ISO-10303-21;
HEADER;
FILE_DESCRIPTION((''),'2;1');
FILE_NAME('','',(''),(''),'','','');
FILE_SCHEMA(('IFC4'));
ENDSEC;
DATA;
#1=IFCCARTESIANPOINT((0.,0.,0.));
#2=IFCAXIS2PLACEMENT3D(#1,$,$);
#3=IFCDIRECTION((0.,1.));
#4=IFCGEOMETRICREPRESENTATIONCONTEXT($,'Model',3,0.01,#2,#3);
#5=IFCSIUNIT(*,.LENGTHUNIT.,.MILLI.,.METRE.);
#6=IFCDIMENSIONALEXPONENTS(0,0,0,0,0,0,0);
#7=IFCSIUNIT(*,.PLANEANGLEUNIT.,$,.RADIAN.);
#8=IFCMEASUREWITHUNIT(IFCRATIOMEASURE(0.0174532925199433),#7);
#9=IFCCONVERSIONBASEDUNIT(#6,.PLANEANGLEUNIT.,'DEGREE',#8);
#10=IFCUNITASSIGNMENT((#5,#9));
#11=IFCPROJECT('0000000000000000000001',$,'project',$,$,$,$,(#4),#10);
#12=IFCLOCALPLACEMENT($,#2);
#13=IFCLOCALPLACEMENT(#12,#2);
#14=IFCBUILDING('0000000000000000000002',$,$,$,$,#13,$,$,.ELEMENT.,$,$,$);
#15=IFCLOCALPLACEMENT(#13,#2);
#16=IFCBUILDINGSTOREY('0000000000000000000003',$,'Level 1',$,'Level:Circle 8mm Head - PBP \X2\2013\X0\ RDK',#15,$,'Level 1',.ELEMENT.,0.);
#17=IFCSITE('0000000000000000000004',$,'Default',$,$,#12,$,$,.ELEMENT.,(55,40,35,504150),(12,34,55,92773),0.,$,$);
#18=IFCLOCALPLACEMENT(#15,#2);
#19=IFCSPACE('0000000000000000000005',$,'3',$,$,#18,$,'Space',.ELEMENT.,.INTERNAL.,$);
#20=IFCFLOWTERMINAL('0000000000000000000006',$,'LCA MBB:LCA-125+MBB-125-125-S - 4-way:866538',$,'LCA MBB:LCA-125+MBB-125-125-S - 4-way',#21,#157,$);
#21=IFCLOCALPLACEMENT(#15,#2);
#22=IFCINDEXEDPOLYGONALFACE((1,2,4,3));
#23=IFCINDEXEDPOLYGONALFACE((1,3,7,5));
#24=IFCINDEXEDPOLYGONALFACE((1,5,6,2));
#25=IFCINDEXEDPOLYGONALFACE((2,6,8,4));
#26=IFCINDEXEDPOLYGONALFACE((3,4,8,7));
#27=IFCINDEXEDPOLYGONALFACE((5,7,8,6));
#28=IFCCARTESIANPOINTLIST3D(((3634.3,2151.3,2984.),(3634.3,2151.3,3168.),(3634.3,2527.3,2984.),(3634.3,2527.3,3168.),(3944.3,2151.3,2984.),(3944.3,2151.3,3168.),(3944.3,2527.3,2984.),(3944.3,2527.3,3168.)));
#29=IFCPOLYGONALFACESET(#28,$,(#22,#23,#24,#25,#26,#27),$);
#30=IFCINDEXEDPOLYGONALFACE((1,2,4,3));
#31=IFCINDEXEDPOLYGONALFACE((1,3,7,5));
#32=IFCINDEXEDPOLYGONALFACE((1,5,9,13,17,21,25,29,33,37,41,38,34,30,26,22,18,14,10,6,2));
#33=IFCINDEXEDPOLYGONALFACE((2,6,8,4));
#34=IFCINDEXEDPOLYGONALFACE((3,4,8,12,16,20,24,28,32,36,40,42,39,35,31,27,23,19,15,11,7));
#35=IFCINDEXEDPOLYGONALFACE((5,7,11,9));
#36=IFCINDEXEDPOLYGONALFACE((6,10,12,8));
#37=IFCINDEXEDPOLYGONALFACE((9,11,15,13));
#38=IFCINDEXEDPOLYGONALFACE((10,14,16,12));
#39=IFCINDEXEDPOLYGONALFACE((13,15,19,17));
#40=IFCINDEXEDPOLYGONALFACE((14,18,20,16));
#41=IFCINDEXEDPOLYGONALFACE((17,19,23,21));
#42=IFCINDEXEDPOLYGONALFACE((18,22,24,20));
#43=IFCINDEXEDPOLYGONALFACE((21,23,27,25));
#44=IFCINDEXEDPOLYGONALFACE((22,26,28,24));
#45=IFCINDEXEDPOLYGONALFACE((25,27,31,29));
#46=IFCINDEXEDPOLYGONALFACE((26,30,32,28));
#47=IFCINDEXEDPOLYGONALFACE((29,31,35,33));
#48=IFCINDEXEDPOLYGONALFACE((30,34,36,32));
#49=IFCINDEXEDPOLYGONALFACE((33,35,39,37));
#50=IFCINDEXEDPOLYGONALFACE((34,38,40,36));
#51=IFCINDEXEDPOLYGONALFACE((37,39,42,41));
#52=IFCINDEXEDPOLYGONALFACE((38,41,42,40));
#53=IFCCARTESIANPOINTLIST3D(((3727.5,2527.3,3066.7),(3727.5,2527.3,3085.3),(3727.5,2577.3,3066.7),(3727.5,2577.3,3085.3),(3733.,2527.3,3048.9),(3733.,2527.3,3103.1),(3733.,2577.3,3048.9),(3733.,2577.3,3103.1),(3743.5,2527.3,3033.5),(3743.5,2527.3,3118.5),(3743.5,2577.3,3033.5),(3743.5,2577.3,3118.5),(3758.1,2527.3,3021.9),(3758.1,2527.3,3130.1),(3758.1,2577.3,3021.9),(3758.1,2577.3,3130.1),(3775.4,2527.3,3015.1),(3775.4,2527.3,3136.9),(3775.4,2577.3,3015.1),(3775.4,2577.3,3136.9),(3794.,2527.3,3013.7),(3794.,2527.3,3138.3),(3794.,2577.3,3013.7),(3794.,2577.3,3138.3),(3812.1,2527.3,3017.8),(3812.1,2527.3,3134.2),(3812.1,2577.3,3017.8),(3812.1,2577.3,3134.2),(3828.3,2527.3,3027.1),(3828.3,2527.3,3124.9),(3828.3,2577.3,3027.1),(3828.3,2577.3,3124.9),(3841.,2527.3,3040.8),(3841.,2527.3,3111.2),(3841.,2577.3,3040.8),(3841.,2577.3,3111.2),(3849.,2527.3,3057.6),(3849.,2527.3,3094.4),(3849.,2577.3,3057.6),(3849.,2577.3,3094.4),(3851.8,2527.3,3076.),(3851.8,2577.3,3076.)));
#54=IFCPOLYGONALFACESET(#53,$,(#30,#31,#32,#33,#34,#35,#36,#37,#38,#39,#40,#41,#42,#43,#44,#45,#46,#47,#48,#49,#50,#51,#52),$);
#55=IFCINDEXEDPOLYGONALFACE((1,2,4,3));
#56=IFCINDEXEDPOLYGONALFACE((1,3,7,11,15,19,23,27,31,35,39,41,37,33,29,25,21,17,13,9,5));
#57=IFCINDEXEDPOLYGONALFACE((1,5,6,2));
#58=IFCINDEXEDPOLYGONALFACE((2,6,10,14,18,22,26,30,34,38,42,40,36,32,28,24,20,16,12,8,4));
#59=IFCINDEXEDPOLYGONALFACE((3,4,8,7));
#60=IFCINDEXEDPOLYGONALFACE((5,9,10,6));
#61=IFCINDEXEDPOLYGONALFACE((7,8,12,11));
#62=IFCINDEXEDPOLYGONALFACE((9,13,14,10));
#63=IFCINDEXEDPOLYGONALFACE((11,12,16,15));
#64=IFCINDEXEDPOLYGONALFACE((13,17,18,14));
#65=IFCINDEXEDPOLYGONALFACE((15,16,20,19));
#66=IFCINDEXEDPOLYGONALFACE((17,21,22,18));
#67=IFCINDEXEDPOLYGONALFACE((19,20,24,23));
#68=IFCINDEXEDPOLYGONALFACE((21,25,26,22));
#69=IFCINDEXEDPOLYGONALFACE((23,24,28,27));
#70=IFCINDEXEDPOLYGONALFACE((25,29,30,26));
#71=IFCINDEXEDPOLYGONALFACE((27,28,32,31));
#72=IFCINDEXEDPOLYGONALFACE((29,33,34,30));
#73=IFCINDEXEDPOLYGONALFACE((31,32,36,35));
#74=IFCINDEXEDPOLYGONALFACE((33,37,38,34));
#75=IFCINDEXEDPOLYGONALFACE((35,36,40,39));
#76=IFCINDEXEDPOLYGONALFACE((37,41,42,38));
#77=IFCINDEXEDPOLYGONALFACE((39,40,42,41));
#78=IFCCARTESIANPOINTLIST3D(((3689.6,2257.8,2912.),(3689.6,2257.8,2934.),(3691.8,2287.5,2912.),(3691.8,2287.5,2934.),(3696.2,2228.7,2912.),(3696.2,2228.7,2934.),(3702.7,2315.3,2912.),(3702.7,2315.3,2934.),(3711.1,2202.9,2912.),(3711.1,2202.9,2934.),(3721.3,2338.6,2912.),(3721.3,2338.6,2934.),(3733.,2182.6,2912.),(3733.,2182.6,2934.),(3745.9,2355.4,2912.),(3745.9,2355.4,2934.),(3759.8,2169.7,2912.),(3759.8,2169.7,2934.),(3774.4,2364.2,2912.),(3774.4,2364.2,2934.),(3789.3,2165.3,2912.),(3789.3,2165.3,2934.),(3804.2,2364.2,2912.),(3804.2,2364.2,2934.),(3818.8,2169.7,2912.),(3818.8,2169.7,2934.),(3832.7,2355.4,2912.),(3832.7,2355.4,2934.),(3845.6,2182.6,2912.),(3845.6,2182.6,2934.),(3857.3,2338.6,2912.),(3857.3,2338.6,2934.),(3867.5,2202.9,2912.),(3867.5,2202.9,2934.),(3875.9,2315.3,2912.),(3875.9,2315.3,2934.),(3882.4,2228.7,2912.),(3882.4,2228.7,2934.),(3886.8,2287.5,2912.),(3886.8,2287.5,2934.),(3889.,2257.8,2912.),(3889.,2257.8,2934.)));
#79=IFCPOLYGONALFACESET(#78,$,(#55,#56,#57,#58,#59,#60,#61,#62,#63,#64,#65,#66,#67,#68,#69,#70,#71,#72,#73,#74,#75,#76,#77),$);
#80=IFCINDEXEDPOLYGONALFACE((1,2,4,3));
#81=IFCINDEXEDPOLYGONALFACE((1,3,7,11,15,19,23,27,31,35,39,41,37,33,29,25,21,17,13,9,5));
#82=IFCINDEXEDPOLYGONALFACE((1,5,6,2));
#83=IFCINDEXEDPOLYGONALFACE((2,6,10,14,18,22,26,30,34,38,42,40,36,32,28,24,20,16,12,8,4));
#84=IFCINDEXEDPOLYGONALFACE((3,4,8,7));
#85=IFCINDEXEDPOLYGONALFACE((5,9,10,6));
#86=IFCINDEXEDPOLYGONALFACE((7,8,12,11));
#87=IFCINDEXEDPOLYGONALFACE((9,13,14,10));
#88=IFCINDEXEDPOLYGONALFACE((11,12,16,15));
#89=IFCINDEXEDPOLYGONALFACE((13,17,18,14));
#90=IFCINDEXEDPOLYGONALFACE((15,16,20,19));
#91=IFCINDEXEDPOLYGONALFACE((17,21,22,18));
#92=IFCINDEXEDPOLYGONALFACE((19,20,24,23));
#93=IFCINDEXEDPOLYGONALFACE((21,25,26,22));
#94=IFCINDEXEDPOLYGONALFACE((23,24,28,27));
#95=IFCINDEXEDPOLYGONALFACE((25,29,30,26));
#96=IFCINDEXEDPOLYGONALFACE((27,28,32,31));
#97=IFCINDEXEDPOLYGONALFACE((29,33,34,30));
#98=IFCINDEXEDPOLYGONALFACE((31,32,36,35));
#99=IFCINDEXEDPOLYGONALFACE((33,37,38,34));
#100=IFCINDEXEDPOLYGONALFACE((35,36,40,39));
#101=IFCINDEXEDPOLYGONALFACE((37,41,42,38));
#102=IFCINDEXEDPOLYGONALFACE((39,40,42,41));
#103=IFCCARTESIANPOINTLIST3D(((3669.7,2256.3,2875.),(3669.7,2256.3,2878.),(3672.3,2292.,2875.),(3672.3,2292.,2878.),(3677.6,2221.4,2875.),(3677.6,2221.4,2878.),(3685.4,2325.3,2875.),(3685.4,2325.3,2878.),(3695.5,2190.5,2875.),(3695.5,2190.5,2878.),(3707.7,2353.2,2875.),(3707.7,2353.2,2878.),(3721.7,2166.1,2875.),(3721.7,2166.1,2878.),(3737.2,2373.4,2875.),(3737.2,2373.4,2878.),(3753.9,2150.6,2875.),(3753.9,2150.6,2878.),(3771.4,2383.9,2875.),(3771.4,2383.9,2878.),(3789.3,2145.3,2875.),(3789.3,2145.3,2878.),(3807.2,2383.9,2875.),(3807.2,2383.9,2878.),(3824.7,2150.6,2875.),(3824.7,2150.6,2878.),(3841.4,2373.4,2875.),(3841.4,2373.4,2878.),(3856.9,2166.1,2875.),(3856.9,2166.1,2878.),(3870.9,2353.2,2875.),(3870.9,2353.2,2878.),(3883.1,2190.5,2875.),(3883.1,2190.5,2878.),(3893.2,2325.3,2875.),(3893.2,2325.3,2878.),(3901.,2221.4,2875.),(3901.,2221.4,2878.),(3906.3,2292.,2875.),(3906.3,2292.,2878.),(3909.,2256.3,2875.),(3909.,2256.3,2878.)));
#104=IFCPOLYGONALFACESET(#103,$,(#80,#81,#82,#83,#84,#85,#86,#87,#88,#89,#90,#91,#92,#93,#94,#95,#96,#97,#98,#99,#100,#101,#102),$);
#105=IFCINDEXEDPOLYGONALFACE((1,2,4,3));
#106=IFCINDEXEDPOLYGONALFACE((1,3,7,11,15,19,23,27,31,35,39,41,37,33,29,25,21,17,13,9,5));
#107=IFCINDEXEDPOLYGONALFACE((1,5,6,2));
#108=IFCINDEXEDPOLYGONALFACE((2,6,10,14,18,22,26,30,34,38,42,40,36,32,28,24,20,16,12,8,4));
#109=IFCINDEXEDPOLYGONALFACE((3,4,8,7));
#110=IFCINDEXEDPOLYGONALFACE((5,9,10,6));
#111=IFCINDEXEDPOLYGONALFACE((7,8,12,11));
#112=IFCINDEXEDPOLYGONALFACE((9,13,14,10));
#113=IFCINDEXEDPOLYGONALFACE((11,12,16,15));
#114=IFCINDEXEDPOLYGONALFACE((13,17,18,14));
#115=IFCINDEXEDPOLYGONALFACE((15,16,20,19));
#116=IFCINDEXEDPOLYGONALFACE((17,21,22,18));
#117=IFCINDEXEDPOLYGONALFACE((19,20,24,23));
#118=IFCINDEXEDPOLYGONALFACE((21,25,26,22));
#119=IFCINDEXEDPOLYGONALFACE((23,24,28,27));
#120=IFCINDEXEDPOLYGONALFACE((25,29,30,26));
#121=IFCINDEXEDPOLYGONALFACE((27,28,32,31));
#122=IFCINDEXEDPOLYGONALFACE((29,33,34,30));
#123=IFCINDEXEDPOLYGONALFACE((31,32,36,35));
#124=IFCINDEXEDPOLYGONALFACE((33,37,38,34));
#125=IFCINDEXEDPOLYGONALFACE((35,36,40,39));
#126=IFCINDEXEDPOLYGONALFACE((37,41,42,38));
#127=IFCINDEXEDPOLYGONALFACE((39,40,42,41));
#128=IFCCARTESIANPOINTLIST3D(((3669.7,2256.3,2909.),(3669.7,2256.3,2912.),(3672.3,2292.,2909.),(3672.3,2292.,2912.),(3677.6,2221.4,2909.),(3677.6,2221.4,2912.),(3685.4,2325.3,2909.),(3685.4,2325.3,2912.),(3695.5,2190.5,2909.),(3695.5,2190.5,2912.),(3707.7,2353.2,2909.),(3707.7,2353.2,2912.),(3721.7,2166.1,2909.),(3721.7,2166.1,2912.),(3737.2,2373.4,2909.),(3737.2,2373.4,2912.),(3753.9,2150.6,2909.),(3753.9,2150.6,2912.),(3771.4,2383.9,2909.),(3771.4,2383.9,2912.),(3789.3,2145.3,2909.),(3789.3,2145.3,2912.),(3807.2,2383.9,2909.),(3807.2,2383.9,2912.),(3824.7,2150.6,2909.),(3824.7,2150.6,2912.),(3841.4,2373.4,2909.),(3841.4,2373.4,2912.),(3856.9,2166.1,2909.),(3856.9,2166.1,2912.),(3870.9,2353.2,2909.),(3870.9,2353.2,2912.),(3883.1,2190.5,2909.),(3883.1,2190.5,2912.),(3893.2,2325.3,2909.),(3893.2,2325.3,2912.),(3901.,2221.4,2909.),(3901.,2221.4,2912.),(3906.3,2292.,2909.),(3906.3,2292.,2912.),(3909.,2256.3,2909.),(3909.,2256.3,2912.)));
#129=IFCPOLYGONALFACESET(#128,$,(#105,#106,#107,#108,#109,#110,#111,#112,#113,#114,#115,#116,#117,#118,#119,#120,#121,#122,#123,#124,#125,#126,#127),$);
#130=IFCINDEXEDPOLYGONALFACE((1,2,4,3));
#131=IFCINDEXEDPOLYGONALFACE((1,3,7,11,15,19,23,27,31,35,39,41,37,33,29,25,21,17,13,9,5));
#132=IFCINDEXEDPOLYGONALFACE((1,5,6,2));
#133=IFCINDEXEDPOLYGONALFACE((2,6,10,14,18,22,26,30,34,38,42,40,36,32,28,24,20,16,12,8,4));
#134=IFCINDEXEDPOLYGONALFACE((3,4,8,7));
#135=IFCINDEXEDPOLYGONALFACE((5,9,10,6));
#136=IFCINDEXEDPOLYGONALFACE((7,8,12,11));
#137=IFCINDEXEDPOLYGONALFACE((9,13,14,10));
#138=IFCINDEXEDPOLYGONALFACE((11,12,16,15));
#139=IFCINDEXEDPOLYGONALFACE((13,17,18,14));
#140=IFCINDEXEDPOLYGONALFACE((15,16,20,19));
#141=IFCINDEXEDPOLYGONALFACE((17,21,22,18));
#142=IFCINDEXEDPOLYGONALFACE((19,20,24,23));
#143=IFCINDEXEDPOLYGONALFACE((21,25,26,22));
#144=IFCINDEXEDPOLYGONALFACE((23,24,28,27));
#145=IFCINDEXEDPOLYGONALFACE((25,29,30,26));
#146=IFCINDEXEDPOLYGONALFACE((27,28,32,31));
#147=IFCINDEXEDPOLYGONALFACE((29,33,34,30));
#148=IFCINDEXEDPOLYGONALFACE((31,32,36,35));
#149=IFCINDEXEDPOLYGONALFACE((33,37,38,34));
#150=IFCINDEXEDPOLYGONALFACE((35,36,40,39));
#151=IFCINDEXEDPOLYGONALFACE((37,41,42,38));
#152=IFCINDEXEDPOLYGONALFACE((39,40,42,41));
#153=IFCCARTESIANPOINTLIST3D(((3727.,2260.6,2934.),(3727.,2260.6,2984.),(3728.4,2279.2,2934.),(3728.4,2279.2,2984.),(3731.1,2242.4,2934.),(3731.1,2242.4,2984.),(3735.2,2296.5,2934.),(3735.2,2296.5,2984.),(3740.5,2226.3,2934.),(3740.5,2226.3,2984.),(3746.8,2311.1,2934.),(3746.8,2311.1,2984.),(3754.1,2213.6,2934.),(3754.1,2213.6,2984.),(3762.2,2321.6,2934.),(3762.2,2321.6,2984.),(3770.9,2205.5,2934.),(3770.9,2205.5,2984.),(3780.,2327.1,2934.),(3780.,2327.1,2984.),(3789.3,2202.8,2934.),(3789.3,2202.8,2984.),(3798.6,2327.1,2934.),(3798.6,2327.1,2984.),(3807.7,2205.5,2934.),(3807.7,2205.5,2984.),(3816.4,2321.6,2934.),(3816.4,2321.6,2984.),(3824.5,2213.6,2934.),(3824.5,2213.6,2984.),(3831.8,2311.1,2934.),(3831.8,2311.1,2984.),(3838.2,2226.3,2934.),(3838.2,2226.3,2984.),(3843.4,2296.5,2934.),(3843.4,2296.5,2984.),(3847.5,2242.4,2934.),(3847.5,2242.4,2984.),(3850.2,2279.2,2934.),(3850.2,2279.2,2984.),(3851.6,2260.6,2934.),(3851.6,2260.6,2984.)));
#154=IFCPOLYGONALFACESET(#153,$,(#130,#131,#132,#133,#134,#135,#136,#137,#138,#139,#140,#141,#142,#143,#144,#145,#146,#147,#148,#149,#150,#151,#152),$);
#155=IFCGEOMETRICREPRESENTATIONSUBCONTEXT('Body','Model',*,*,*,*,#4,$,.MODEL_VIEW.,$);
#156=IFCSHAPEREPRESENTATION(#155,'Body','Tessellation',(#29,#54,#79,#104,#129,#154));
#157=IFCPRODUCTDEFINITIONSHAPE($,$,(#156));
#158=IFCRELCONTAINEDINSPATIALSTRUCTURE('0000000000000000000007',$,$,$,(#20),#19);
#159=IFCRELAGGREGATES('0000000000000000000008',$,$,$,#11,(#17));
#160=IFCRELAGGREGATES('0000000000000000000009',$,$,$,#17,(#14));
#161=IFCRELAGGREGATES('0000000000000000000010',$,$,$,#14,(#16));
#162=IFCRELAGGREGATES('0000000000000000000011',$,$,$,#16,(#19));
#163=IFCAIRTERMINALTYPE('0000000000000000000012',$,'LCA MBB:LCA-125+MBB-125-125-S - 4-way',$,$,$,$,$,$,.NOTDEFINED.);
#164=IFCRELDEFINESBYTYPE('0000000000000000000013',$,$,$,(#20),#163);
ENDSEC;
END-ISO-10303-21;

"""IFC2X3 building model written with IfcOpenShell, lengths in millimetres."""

from ifc_helpers import new_model, entity, si_unit, converted_unit, direction, frame, frame_2d, origin, origin_2d_with_axis, place, context, subcontext, project, spatial, rectangle, circle, extrude, source, transform, mapped, type_object, type_shapes, element, save


model = new_model("IFC2X3")

# Units and contexts
model_context = context("Model", 3, precision=0.01, world=origin(), true_north=direction((0.0, 1.0)))
body_context = subcontext(model_context, "Body", "Model", "MODEL_VIEW")
ifc_project = project(units=[si_unit("LENGTHUNIT", "METRE", prefix="MILLI"), converted_unit("PLANEANGLEUNIT", "DEGREE", entity("IfcRatioMeasure", 0.0174532925199433), si_unit("PLANEANGLEUNIT", "RADIAN"), dimensions=[0, 0, 0, 0, 0, 0, 0])], contexts=[model_context])

# Site, building, storey, space
site_placement = place(None, origin())
site = spatial("IfcSite", under=ifc_project, at=site_placement, Name="Default", CompositionType="ELEMENT", RefLatitude=(55, 40, 35, 504150), RefLongitude=(12, 34, 55, 92773), RefElevation=0.0)
building_placement = place(site_placement, origin())
building = spatial("IfcBuilding", under=site, at=building_placement, CompositionType="ELEMENT")
storey_placement = place(building_placement, origin())
storey = spatial("IfcBuildingStorey", under=building, at=storey_placement, Name="Level 1", ObjectType="Level:Circle 8mm Head - PBP – RDK", LongName="Level 1", CompositionType="ELEMENT", Elevation=0.0)
space_1_placement = place(storey_placement, origin())
space_1 = spatial("IfcSpace", under=storey, at=space_1_placement, Name="3", LongName="Space", CompositionType="ELEMENT", InteriorOrExteriorSpace="INTERNAL")

# Flow terminal
air_terminal_type_1 = type_object("IfcAirTerminalType", Name="LCA MBB:LCA-125+MBB-125-125-S - 4-way", PredefinedType="NOTDEFINED")
shared_shape_1 = source(origin(), body_context, "Body", "SweptSolid", [
    extrude(rectangle(XDim=310.0, YDim=376.0, at=origin_2d_with_axis()), frame((-74.0, 0.0, 72.0), z_axis=(0.0, 0.0, 1.0), x_axis=(0.0, -1.0, 0.0)), (0.0, 0.0, 1.0), 184.0),
    extrude(circle(Radius=62.5, at=frame_2d((0.0, 0.0), x_axis=(1.0, 0.0))), frame((-312.0, 0.0, 164.0), z_axis=(1.0, 0.0, 0.0), x_axis=(0.0, 1.0, 0.0)), (0.0, 0.0, 1.0), 50.0),
    extrude(circle(Radius=100.0, at=frame_2d((0.0, 0.0), x_axis=(1.0, 0.0))), origin(), (0.0, 0.0, 1.0), 22.0),
    extrude(circle(Radius=120.0, at=frame_2d((0.0, 0.0), x_axis=(1.0, 0.0))), frame((0.0, 0.0, -37.0)), (0.0, 0.0, 1.0), 3.0),
    extrude(circle(Radius=120.0, at=frame_2d((0.0, 0.0), x_axis=(1.0, 0.0))), frame((0.0, 0.0, -3.0)), (0.0, 0.0, 1.0), 3.0),
    extrude(circle(Radius=62.5, at=frame_2d((0.0, 0.0), x_axis=(1.0, 0.0))), frame((0.0, 0.0, 22.0)), (0.0, 0.0, 1.0), 50.0),
])
type_shapes(air_terminal_type_1, [shared_shape_1])
flow_terminal_1_placement = place(space_1_placement, frame((3789.3, 2265.3, 2912.0), z_axis=(0.0, 0.0, 1.0), x_axis=(0.0, -1.0, 0.0)))
element("IfcFlowTerminal", 1, at=flow_terminal_1_placement, inside=space_1, type_object=air_terminal_type_1, Name="LCA MBB:LCA-125+MBB-125-125-S - 4-way:866538", ObjectType="LCA MBB:LCA-125+MBB-125-125-S - 4-way", context=body_context, shape_type="MappedRepresentation", body=[
    mapped(shared_shape_1, transform((0.0, 0.0, 0.0), scale=1.0)),
])

save(model, "model.ifc")
